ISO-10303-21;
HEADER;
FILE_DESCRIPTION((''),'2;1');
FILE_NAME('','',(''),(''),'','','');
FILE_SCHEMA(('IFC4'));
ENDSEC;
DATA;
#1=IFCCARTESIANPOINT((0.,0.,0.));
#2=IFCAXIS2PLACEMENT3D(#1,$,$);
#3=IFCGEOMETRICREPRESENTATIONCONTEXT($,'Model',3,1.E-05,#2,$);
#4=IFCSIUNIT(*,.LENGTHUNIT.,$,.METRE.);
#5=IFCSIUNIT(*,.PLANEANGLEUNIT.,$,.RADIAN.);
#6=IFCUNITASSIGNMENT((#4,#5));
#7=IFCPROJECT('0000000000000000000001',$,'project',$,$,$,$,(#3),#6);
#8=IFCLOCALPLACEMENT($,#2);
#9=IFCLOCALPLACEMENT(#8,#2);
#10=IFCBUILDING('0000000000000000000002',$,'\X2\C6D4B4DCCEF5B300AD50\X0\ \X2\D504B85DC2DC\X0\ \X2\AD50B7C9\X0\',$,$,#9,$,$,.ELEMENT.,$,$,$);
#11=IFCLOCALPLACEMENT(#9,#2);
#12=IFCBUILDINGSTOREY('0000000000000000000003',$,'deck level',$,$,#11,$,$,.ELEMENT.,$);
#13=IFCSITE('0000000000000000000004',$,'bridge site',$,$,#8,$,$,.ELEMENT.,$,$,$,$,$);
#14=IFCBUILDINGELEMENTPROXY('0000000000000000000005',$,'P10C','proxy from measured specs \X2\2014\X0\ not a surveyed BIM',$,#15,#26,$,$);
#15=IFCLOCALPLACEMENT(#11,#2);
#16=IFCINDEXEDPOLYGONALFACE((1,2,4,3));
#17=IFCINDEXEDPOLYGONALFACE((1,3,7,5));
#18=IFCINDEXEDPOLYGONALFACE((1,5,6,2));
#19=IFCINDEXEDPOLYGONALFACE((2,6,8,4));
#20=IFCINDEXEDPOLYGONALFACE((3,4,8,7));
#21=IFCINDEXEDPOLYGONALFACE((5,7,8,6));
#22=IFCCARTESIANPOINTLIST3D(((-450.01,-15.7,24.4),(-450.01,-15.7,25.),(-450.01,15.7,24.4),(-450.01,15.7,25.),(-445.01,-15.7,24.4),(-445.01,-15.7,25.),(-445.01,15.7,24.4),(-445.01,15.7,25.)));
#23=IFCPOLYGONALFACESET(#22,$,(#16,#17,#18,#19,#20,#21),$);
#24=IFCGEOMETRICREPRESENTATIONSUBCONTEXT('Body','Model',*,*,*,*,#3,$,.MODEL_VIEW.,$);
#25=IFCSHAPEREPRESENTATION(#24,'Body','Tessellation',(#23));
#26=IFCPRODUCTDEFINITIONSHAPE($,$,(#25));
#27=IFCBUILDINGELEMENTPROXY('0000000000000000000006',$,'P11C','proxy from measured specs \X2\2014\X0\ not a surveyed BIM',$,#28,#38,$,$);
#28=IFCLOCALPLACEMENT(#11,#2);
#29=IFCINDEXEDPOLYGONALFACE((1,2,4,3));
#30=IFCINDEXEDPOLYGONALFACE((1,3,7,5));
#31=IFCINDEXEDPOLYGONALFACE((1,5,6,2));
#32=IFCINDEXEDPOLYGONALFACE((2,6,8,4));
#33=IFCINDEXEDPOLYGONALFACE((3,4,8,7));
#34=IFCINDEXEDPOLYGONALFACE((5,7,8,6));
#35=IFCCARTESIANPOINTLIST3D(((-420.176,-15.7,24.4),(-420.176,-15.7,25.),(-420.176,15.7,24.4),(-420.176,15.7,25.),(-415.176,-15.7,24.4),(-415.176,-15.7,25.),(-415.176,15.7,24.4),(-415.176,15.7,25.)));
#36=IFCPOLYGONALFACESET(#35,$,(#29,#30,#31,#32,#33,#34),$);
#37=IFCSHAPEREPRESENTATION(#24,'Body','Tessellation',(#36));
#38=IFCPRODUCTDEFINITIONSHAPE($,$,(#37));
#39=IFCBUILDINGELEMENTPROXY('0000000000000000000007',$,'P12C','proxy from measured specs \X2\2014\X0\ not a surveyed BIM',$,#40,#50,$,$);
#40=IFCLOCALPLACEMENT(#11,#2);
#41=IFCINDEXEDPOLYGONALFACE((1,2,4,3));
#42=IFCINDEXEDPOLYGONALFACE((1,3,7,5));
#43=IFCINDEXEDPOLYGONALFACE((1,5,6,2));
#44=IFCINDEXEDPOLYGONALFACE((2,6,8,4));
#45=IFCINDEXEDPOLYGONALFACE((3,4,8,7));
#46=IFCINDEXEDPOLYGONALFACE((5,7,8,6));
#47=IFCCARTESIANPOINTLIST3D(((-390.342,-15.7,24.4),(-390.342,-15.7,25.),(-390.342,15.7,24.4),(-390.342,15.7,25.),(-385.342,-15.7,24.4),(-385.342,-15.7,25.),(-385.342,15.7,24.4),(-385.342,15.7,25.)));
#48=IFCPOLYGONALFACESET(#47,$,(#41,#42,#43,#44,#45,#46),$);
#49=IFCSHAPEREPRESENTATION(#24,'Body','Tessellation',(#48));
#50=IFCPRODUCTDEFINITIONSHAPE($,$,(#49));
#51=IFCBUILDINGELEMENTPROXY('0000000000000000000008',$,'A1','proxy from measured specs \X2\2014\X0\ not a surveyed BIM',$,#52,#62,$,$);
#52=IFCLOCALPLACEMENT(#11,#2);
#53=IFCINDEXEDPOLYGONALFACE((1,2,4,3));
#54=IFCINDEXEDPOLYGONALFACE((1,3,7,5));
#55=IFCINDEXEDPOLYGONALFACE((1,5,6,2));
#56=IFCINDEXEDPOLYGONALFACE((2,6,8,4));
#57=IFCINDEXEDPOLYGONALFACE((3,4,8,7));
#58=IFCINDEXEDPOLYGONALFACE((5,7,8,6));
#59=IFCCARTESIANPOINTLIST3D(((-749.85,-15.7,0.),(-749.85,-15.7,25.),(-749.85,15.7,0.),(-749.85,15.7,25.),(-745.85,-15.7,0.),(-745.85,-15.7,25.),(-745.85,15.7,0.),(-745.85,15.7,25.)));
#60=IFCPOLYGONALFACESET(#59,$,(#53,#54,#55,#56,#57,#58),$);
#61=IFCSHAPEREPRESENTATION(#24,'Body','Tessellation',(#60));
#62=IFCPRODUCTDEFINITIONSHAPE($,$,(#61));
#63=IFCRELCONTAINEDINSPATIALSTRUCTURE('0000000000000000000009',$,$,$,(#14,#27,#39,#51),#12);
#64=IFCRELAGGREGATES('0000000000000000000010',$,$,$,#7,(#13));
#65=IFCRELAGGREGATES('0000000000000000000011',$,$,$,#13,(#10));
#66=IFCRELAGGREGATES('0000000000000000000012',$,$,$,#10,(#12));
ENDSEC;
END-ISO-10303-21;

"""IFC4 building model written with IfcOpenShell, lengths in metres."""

from ifc_helpers import new_model, si_unit, frame, origin, origin_2d, place, context, subcontext, project, spatial, rectangle, extrude, element, save


model = new_model("IFC4")

# Units and contexts
model_context = context("Model", 3, precision=1e-05, world=origin())
body_context = subcontext(model_context, "Body", "Model", "MODEL_VIEW")
ifc_project = project(units=[si_unit("LENGTHUNIT", "METRE"), si_unit("PLANEANGLEUNIT", "RADIAN")], contexts=[model_context])

# Site, building, storey
site_placement = place(None, origin())
site = spatial("IfcSite", under=ifc_project, at=site_placement, Name="bridge site", CompositionType="ELEMENT")
building_placement = place(site_placement, origin())
building = spatial("IfcBuilding", under=site, at=building_placement, Name="월드컵대교 프록시 교량", CompositionType="ELEMENT")
storey_placement = place(building_placement, origin())
storey = spatial("IfcBuildingStorey", under=building, at=storey_placement, Name="deck level", CompositionType="ELEMENT")

# Building element proxies
for number, where, name in (
    (1, (-447.51, 0.0, 24.4), "P10C"),
    (2, (-417.676, 0.0, 24.4), "P11C"),
    (3, (-387.842, 0.0, 24.4), "P12C"),
):
    element("IfcBuildingElementProxy", number, at=place(storey_placement, frame(where)), inside=storey, Name=name, Description="proxy from measured specs — not a surveyed BIM", context=body_context, shape_type="SweptSolid", body=[
        extrude(rectangle(XDim=5.0, YDim=31.4, at=origin_2d()), origin(), (0.0, 0.0, 1.0), 0.6),
    ])
proxy_placement = place(storey_placement, frame((-747.85, 0.0, 0.0)))
element("IfcBuildingElementProxy", 4, at=proxy_placement, inside=storey, Name="A1", Description="proxy from measured specs — not a surveyed BIM", context=body_context, shape_type="SweptSolid", body=[
    extrude(rectangle(XDim=4.0, YDim=31.4, at=origin_2d()), origin(), (0.0, 0.0, 1.0), 25.0),
])

save(model, "model.ifc")
